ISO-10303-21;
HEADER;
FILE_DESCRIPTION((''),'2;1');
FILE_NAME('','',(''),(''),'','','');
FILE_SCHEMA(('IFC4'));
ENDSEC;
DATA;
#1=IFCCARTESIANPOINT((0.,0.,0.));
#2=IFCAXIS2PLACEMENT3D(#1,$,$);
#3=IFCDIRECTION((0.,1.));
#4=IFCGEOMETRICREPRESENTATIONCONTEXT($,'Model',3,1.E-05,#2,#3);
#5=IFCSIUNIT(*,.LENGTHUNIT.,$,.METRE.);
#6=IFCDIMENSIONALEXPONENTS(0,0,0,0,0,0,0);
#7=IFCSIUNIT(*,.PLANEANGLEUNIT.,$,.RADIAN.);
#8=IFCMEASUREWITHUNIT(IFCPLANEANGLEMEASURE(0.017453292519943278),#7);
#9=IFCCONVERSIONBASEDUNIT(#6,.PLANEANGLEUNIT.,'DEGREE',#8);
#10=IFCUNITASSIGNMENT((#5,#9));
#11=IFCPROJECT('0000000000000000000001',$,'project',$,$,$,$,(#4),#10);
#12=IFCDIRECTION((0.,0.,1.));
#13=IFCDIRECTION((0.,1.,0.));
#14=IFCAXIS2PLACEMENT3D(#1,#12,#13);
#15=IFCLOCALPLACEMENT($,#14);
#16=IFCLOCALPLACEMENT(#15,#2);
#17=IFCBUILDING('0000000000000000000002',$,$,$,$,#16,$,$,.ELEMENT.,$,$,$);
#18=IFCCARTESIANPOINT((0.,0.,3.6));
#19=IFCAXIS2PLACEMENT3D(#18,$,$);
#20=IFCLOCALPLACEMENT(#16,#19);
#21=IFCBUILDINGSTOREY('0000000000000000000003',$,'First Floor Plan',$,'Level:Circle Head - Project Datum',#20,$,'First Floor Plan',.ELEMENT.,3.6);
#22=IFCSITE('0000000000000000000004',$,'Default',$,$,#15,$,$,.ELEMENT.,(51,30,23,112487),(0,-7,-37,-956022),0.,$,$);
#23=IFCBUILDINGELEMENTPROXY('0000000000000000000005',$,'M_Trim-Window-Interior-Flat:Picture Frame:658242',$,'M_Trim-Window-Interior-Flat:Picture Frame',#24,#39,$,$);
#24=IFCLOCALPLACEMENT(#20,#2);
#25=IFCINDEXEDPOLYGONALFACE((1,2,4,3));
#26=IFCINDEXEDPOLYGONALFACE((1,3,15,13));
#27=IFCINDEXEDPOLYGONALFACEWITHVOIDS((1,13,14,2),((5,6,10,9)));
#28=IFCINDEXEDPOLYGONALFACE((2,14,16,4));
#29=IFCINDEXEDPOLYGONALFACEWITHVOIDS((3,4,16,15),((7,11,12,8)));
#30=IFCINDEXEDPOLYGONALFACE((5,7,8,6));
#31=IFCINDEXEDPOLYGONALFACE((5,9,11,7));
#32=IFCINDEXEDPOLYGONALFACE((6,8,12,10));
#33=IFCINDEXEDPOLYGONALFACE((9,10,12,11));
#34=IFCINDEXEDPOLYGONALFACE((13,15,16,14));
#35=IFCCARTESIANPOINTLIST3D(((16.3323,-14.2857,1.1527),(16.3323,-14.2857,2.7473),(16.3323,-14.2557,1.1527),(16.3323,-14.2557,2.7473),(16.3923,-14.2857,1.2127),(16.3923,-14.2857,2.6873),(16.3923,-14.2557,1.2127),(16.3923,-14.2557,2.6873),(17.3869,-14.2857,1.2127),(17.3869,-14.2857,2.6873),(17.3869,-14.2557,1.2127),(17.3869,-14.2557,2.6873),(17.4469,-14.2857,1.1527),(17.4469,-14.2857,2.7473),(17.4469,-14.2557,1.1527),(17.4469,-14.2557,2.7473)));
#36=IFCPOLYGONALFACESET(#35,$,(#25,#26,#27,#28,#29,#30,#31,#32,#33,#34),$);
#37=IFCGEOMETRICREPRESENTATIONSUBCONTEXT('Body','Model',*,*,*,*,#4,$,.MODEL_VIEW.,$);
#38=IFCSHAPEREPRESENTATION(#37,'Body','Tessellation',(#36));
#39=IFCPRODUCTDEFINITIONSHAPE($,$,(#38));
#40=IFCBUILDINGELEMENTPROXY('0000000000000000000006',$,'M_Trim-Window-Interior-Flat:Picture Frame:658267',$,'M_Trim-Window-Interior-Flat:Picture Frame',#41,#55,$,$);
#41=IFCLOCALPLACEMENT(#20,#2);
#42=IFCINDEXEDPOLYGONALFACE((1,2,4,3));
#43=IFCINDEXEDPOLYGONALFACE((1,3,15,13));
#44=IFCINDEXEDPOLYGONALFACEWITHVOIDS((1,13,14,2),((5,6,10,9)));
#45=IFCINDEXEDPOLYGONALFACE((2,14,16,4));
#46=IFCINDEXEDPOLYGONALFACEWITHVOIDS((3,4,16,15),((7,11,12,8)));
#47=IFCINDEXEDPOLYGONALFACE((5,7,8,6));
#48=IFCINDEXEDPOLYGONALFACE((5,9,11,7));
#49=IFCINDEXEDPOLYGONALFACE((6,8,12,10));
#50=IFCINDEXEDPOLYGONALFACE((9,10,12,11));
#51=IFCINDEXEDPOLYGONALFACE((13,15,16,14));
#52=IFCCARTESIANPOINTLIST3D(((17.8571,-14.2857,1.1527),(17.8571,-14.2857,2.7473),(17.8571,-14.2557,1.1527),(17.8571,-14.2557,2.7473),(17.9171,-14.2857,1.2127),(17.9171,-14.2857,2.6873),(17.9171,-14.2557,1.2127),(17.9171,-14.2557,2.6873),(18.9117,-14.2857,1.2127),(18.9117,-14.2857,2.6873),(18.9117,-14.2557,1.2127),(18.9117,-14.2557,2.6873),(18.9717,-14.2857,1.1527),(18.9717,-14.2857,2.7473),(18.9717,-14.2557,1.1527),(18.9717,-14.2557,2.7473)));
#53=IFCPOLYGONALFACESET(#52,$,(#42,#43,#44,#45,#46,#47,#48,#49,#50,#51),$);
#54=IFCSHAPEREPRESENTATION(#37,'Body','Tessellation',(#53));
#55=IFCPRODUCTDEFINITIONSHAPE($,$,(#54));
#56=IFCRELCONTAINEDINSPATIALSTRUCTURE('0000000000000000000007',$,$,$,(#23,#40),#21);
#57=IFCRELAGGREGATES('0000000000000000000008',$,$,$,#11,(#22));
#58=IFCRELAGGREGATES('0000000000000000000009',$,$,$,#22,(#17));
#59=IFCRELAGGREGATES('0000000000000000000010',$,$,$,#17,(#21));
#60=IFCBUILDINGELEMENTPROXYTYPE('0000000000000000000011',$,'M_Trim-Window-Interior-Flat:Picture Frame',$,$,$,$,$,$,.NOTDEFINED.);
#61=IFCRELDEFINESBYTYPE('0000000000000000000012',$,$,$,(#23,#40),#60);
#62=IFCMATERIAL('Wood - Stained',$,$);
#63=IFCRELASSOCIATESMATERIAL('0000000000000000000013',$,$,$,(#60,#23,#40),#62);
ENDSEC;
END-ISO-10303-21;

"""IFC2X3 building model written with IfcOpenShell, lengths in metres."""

from ifc_helpers import new_model, entity, si_unit, converted_unit, direction, frame, origin, place, context, subcontext, project, spatial, polyline, outline, extrude, source, transform, mapped, material, type_object, type_shapes, element, save


model = new_model("IFC2X3")

# Units and contexts
model_context = context("Model", 3, precision=1e-05, world=origin(), true_north=direction((0.0, 1.0)))
body_context = subcontext(model_context, "Body", "Model", "MODEL_VIEW")
ifc_project = project(units=[si_unit("LENGTHUNIT", "METRE"), converted_unit("PLANEANGLEUNIT", "DEGREE", entity("IfcPlaneAngleMeasure", 0.017453292519943278), si_unit("PLANEANGLEUNIT", "RADIAN"), dimensions=[0, 0, 0, 0, 0, 0, 0])], contexts=[model_context])

# Site, building, storey
site_placement = place(None, frame((0.0, 0.0, 0.0), z_axis=(0.0, 0.0, 1.0), x_axis=(0.0, 1.0, 0.0)))
site = spatial("IfcSite", under=ifc_project, at=site_placement, Name="Default", CompositionType="ELEMENT", RefLatitude=(51, 30, 23, 112487), RefLongitude=(0, -7, -37, -956022), RefElevation=0.0)
building_placement = place(site_placement, origin())
building = spatial("IfcBuilding", under=site, at=building_placement, CompositionType="ELEMENT")
storey_placement = place(building_placement, frame((0.0, 0.0, 3.6)))
storey = spatial("IfcBuildingStorey", under=building, at=storey_placement, Name="First Floor Plan", ObjectType="Level:Circle Head - Project Datum", LongName="First Floor Plan", CompositionType="ELEMENT", Elevation=3.6)

# Building element proxies
ifc_material_1 = material(Name="Wood - Stained")
building_element_proxy_type_1 = type_object("IfcBuildingElementProxyType", Name="M_Trim-Window-Interior-Flat:Picture Frame", PredefinedType="NOTDEFINED", material=ifc_material_1)
shared_shape_1 = source(origin(), body_context, "Body", "SweptSolid", [
    extrude(outline(polyline([(-0.7973, -0.5573), (0.7973, -0.5573), (0.7973, 0.5573), (-0.7973, 0.5573), (-0.7973, -0.5573)]), holes=[polyline([(-0.7373, -0.4973), (-0.7373, 0.4973), (0.7373, 0.4973), (0.7373, -0.4973), (-0.7373, -0.4973)])]), frame((0.0, 0.75, 0.0), z_axis=(0.0, 0.0, 1.0), x_axis=(0.0, 1.0, 0.0)), (0.0, 0.0, 1.0), 0.03),
])
type_shapes(building_element_proxy_type_1, [shared_shape_1])
for number, where, z_axis, x_axis, name in (
    (1, (16.8896, -14.2857, 2.7), (0.0, 1.0, 0.0), (1.0, 0.0, 0.0), "M_Trim-Window-Interior-Flat:Picture Frame:658242"),
    (2, (18.4144, -14.2857, 2.7), (0.0, 1.0, 0.0), (1.0, 0.0, 0.0), "M_Trim-Window-Interior-Flat:Picture Frame:658267"),
):
    element("IfcBuildingElementProxy", number, at=place(storey_placement, frame(where, z_axis=z_axis, x_axis=x_axis)), inside=storey, type_object=building_element_proxy_type_1, material=ifc_material_1, Name=name, ObjectType="M_Trim-Window-Interior-Flat:Picture Frame", context=body_context, shape_type="MappedRepresentation", body=[
        mapped(shared_shape_1, transform((0.0, 0.0, 0.0), scale=1.0)),
    ])

save(model, "model.ifc")
